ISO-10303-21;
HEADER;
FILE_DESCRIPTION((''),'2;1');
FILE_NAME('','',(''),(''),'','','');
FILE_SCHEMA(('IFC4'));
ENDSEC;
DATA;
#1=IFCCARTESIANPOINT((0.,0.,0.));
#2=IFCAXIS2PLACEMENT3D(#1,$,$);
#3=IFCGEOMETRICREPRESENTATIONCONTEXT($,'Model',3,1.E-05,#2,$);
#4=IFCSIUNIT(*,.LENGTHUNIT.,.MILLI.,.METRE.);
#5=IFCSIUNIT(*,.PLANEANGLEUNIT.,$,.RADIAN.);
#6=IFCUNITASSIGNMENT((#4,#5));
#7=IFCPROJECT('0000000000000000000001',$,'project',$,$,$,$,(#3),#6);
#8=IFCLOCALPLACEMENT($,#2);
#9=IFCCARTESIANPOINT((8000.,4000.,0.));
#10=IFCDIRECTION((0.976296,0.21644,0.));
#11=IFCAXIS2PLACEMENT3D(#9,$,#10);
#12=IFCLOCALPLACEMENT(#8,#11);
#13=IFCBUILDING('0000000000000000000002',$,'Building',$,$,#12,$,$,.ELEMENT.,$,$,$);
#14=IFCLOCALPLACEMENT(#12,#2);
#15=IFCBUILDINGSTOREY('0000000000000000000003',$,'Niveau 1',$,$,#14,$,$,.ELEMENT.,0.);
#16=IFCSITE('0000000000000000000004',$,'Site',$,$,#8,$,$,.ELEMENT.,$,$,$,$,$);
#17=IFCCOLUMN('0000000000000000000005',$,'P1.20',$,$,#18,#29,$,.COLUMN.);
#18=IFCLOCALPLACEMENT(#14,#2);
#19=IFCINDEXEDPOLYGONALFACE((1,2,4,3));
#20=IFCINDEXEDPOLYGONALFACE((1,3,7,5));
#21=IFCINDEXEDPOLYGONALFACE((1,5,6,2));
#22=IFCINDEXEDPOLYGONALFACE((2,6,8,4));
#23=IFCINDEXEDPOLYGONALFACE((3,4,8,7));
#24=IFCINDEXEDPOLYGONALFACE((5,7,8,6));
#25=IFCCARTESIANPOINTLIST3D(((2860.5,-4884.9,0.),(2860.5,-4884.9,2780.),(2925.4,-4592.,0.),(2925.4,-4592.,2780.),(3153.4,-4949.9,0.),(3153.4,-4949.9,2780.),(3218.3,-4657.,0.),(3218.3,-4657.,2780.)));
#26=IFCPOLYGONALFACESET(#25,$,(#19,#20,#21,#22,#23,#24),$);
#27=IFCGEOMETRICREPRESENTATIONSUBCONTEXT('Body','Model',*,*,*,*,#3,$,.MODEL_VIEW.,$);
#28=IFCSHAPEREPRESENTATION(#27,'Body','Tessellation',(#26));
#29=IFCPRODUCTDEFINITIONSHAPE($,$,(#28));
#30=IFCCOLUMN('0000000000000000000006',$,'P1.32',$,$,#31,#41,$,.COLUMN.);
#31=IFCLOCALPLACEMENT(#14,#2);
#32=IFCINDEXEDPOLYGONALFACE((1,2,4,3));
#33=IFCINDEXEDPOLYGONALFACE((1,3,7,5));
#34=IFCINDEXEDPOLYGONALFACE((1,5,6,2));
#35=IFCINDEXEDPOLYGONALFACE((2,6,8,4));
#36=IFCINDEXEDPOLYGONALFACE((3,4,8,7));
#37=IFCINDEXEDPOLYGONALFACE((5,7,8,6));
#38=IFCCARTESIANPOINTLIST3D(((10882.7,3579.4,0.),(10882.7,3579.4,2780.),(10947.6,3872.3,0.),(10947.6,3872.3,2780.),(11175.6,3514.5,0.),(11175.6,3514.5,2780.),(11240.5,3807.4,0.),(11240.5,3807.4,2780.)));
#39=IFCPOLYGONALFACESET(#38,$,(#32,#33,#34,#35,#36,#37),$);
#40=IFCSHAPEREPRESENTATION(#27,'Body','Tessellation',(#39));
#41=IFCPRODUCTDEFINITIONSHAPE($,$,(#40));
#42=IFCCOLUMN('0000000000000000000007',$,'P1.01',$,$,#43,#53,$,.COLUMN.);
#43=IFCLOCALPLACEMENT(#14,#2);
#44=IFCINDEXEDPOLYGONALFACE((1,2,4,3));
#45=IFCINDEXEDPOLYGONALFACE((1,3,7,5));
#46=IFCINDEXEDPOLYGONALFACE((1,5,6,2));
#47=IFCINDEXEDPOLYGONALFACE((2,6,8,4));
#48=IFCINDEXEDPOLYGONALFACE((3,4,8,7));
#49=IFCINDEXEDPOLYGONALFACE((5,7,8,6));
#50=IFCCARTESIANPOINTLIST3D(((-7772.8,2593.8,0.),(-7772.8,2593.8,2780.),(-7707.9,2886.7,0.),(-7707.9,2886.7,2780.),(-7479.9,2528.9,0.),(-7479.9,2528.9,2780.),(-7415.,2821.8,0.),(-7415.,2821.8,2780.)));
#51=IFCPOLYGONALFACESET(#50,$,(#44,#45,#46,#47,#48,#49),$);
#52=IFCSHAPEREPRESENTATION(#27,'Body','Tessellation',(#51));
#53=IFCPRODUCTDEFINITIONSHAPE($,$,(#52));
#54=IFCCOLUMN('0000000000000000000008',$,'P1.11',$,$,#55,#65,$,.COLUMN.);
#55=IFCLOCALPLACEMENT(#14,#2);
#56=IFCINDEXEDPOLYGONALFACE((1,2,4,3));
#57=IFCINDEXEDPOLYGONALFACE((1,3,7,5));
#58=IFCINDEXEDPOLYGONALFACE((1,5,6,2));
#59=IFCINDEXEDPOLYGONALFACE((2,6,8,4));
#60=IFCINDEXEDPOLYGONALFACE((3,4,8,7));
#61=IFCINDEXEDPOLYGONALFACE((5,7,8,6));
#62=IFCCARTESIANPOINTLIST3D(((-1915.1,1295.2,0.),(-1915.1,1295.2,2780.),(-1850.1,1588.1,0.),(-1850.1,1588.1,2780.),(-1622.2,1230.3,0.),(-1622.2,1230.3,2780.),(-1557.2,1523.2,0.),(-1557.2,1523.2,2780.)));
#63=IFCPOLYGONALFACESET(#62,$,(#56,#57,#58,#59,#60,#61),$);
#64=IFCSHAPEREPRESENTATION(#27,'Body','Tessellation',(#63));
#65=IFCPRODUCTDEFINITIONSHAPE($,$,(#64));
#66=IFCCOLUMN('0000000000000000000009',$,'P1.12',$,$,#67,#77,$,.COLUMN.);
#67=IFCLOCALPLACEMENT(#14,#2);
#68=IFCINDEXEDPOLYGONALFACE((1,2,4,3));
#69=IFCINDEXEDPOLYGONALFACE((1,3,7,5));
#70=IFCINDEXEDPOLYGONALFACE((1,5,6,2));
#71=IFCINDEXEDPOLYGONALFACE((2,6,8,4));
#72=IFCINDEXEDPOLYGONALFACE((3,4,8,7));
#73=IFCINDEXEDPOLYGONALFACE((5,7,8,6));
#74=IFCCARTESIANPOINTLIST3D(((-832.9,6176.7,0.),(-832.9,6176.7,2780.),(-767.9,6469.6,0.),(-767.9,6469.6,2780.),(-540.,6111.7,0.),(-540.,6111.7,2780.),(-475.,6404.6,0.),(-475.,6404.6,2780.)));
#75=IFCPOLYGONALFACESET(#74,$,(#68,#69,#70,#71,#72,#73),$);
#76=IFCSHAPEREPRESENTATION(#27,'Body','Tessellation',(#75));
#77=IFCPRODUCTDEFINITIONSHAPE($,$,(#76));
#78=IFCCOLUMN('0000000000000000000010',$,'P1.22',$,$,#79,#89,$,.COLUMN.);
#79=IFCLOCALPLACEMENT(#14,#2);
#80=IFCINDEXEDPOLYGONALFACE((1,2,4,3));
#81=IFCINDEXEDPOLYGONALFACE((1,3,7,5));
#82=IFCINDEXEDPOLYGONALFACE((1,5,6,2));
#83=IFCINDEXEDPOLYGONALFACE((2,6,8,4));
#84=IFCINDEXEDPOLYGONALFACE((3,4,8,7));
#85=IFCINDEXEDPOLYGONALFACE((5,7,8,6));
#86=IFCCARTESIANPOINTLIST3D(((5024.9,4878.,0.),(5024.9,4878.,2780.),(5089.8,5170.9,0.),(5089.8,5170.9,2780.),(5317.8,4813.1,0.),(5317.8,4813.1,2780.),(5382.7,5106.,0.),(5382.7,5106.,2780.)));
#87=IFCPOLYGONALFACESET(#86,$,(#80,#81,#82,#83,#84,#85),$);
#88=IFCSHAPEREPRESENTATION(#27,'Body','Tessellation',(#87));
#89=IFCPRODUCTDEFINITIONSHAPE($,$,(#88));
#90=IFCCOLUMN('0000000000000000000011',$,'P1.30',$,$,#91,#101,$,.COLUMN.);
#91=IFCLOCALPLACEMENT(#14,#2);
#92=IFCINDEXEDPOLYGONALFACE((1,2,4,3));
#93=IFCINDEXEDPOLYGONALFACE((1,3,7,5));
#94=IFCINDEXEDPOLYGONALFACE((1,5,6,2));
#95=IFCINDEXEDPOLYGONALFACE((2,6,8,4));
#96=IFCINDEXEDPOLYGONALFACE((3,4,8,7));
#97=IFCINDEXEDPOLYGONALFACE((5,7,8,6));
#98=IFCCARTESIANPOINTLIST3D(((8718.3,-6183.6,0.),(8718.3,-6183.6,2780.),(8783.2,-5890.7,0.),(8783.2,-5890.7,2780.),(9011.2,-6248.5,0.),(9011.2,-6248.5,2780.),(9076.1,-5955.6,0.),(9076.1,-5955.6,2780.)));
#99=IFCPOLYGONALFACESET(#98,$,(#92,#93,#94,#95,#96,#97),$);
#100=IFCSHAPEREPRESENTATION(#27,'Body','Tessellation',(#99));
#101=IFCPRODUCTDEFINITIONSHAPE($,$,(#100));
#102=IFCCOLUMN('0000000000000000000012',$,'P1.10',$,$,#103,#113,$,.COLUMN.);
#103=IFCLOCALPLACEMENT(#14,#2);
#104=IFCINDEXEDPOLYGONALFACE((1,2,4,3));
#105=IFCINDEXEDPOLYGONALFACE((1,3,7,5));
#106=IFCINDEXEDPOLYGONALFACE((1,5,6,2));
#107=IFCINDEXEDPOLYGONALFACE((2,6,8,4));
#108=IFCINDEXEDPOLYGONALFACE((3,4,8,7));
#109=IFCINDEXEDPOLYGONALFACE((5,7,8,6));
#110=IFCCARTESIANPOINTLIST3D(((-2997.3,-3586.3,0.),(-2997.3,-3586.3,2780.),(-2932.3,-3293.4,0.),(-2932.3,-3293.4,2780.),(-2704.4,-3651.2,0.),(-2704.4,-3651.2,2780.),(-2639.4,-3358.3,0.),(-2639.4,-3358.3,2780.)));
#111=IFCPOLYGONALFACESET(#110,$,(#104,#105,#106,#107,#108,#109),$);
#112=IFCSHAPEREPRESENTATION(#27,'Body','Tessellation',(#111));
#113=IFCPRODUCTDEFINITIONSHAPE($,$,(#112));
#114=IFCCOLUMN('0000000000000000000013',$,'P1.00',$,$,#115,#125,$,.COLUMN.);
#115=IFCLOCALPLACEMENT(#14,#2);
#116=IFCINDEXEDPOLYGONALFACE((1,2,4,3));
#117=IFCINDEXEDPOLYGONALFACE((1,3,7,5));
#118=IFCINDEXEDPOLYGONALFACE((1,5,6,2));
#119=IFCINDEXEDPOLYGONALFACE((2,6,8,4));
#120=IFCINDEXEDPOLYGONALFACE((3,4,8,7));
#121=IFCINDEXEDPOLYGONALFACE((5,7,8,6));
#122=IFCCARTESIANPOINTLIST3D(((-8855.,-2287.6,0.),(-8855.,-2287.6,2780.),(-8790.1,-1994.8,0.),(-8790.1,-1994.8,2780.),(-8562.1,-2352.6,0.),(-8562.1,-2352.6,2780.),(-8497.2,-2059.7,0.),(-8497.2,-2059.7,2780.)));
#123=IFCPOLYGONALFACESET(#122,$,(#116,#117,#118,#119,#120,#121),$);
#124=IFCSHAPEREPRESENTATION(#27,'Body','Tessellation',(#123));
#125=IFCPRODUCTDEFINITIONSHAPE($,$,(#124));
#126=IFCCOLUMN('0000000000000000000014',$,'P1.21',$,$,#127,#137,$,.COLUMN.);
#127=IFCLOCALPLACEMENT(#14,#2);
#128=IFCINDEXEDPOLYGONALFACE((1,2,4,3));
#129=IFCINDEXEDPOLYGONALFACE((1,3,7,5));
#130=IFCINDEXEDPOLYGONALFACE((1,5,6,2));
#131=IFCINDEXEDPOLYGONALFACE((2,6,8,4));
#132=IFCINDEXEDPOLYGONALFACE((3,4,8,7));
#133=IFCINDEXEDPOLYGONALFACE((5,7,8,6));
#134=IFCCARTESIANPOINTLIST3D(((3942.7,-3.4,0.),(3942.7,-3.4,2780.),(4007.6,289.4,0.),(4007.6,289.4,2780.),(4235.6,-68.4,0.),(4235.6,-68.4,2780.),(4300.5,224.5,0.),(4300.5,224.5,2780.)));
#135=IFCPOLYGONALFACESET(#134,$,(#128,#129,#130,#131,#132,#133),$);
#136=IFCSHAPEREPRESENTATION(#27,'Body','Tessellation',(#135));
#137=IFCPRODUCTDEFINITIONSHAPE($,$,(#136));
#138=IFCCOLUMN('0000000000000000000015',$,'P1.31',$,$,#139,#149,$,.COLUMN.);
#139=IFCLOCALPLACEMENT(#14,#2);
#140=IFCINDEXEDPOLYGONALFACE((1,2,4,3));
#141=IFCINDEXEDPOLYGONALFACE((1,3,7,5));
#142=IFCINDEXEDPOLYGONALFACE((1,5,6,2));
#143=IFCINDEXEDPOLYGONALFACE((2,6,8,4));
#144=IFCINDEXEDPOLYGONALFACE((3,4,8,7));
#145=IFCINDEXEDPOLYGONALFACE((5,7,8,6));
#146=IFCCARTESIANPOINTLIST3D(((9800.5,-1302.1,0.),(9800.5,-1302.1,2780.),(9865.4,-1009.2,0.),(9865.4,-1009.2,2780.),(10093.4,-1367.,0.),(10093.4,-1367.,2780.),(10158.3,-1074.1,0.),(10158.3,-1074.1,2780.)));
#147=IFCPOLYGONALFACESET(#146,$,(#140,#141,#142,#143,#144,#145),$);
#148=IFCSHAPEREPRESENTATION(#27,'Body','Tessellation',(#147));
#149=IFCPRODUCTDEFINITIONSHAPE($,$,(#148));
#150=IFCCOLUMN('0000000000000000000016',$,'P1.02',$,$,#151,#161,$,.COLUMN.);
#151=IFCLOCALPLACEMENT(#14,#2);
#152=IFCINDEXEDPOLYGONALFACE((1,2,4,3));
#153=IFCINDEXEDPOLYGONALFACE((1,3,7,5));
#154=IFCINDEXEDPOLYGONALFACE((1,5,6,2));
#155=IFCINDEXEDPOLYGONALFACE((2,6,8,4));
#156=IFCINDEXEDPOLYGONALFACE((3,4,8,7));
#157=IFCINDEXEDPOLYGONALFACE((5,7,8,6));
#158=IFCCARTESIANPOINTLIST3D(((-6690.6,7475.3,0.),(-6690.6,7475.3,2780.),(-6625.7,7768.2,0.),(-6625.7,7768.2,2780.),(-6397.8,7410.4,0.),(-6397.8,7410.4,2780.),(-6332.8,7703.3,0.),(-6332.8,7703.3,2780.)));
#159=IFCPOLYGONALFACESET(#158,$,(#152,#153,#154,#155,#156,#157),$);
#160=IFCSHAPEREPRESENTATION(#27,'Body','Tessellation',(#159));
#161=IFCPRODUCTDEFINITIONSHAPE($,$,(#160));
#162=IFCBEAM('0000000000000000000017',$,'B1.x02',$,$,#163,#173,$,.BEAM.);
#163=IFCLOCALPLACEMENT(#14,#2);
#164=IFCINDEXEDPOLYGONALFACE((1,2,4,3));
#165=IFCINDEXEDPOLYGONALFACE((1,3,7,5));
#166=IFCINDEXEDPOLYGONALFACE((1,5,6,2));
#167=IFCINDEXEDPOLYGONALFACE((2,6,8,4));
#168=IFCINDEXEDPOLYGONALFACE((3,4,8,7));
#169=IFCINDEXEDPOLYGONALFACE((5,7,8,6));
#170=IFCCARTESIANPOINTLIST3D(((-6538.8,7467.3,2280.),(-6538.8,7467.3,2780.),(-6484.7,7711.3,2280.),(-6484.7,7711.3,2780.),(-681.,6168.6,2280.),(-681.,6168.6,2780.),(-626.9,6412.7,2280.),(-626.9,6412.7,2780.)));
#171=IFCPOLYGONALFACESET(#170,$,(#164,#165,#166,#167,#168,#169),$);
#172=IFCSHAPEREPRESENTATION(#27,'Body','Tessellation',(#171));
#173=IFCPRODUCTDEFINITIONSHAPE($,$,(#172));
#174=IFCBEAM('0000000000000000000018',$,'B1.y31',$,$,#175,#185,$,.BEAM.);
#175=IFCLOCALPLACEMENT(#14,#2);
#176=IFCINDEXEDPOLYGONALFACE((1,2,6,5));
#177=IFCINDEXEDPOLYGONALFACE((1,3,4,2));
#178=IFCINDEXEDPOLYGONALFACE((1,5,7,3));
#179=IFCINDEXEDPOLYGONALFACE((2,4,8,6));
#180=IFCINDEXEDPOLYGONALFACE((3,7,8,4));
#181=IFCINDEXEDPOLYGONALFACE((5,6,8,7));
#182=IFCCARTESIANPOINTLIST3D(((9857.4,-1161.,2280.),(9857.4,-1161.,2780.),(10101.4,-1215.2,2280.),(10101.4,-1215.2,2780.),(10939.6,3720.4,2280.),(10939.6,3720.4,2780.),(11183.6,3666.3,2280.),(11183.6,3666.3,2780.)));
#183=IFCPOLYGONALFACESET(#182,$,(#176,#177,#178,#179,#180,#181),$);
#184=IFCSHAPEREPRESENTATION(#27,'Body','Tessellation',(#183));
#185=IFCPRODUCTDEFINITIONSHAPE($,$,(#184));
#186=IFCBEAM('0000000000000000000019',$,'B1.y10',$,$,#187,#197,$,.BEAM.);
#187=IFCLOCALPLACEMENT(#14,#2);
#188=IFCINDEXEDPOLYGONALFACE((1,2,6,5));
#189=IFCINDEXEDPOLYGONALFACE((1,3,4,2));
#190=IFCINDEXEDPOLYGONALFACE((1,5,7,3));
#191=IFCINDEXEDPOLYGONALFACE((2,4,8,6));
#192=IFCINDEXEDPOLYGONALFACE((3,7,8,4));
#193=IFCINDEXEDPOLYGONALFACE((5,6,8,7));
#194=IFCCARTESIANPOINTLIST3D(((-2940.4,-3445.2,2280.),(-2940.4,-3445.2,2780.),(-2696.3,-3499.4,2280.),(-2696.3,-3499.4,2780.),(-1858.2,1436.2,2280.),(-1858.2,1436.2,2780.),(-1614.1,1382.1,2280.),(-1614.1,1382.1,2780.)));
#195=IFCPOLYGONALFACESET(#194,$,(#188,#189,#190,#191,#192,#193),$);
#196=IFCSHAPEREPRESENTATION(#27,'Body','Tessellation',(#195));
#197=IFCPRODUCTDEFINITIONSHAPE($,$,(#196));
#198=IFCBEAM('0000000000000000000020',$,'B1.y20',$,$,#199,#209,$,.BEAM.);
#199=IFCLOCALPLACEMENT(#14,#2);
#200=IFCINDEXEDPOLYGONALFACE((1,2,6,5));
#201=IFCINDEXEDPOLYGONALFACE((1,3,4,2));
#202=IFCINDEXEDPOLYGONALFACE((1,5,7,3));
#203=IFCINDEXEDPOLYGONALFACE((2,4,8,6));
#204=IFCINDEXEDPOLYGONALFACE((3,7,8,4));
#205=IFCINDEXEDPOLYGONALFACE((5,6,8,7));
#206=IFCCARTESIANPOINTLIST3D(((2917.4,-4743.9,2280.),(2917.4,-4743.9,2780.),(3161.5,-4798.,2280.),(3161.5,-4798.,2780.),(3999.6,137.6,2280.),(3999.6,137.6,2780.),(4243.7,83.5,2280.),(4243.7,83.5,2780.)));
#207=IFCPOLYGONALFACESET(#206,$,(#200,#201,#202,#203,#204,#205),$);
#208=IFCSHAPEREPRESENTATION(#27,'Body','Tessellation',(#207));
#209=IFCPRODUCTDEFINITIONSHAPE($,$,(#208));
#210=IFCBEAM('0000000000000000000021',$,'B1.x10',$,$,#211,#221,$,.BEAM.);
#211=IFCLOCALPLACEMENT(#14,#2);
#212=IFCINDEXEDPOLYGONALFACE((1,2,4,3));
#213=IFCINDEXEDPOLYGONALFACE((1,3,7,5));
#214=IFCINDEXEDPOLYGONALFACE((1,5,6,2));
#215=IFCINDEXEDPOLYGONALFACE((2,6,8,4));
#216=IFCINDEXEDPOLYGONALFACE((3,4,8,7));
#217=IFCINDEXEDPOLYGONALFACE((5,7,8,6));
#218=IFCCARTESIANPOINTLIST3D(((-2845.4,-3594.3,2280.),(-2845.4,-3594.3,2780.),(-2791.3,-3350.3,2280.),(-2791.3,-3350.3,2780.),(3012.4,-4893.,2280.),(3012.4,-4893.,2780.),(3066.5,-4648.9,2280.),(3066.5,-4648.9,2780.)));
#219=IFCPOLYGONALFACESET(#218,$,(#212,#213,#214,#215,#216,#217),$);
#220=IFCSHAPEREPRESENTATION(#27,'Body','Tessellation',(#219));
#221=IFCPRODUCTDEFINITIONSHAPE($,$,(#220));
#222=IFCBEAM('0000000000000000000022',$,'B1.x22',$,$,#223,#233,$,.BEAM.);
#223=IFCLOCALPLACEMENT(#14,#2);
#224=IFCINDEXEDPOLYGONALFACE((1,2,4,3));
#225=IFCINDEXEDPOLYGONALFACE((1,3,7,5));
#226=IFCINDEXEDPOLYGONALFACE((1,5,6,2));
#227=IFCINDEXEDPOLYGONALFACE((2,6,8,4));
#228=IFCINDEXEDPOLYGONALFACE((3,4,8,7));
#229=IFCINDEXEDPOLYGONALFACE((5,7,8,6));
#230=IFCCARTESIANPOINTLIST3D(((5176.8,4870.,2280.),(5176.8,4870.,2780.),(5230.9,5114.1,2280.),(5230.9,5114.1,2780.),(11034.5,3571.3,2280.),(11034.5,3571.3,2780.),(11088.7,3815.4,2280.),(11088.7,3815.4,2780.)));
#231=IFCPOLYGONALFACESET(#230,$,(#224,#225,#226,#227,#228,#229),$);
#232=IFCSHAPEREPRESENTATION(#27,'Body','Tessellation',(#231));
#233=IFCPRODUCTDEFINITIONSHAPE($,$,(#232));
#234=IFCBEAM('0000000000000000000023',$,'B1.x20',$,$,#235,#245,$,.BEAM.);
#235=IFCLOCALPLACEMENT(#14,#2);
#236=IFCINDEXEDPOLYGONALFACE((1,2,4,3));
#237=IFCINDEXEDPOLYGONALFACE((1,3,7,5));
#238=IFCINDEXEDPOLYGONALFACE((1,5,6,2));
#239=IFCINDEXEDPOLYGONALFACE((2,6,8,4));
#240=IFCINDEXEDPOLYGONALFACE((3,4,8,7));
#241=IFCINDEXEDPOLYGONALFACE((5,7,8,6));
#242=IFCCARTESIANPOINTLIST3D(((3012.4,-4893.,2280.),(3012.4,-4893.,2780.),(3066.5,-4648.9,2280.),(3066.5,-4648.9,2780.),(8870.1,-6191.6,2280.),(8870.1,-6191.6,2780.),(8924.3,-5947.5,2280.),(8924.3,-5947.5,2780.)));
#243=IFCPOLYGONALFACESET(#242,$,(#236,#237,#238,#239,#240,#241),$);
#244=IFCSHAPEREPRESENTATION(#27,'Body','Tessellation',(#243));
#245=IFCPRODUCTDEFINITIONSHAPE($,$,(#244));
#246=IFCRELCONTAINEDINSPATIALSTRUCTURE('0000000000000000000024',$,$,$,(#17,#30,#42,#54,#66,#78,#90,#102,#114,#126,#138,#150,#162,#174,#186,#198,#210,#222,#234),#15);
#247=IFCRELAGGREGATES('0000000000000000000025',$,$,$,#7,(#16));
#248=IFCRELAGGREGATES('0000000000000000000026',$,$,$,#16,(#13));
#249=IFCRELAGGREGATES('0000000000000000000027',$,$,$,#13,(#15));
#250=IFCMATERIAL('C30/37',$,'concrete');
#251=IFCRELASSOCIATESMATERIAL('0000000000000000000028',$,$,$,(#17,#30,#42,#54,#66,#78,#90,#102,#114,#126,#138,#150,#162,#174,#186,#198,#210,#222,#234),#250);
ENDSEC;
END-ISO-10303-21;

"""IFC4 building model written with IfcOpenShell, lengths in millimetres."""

from ifc_helpers import new_model, si_unit, frame, origin, place, context, subcontext, project, spatial, rectangle, extrude, material, element, save


model = new_model("IFC4")

# Units and contexts
model_context = context("Model", 3, precision=1e-05, world=origin())
body_context = subcontext(model_context, "Body", "Model", "MODEL_VIEW")
ifc_project = project(units=[si_unit("LENGTHUNIT", "METRE", prefix="MILLI"), si_unit("PLANEANGLEUNIT", "RADIAN")], contexts=[model_context])

# Site, building, storey
site_placement = place(None, origin())
site = spatial("IfcSite", under=ifc_project, at=site_placement, Name="Site", CompositionType="ELEMENT")
building_placement = place(site_placement, frame((8000.0, 4000.0, 0.0), x_axis=(0.976296, 0.21644, 0.0)))
building = spatial("IfcBuilding", under=site, at=building_placement, Name="Building", CompositionType="ELEMENT")
storey_placement = place(building_placement, origin())
storey = spatial("IfcBuildingStorey", under=building, at=storey_placement, Name="Niveau 1", CompositionType="ELEMENT", Elevation=0.0)

# Columns
ifc_material = material(Name="C30/37", Category="concrete")
for number, where, z_axis, x_axis, name in (
    (1, (3039.4, -4770.9, 0.0), (0.0, 0.0, 1.0), (0.976296, -0.21644, 0.0), "P1.20"),
    (2, (11061.6, 3693.4, 0.0), (0.0, 0.0, 1.0), (0.976296, -0.21644, 0.0), "P1.32"),
    (3, (-7593.9, 2707.8, 0.0), (0.0, 0.0, 1.0), (0.976296, -0.21644, 0.0), "P1.01"),
    (4, (-1736.2, 1409.2, 0.0), (0.0, 0.0, 1.0), (0.976296, -0.21644, 0.0), "P1.11"),
    (5, (-654.0, 6290.7, 0.0), (0.0, 0.0, 1.0), (0.976296, -0.21644, 0.0), "P1.12"),
    (6, (5203.8, 4992.0, 0.0), (0.0, 0.0, 1.0), (0.976296, -0.21644, 0.0), "P1.22"),
    (7, (8897.2, -6069.6, 0.0), (0.0, 0.0, 1.0), (0.976296, -0.21644, 0.0), "P1.30"),
    (8, (-2818.4, -3472.3, 0.0), (0.0, 0.0, 1.0), (0.976296, -0.21644, 0.0), "P1.10"),
    (9, (-8676.1, -2173.7, 0.0), (0.0, 0.0, 1.0), (0.976296, -0.21644, 0.0), "P1.00"),
    (10, (4121.6, 110.5, 0.0), (0.0, 0.0, 1.0), (0.976296, -0.21644, 0.0), "P1.21"),
    (11, (9979.4, -1188.1, 0.0), (0.0, 0.0, 1.0), (0.976296, -0.21644, 0.0), "P1.31"),
    (12, (-6511.7, 7589.3, 0.0), (0.0, 0.0, 1.0), (0.976296, -0.21644, 0.0), "P1.02"),
):
    element("IfcColumn", number, at=place(storey_placement, frame(where, z_axis=z_axis, x_axis=x_axis)), inside=storey, material=ifc_material, Name=name, PredefinedType="COLUMN", context=body_context, shape_type="SweptSolid", body=[
        extrude(rectangle(XDim=300.0, YDim=300.0), origin(), (0.0, 0.0, 1.0), 2780.0),
    ])

# Beams
beam_1_placement = place(storey_placement, frame((-6511.7, 7589.3, 2530.0), z_axis=(0.976296, -0.21644, 0.0), x_axis=(0.21644, 0.976296, 0.0)))
element("IfcBeam", 13, at=beam_1_placement, inside=storey, material=ifc_material, Name="B1.x02", PredefinedType="BEAM", context=body_context, shape_type="SweptSolid", body=[
    extrude(rectangle(XDim=250.0, YDim=500.0), origin(), (0.0, 0.0, 1.0), 6000.0),
])
for number, where, z_axis, x_axis, name in (
    (14, (9979.4, -1188.1, 2530.0), (0.21644, 0.976296, 0.0), (-0.976296, 0.21644, 0.0), "B1.y31"),
    (15, (-2818.4, -3472.3, 2530.0), (0.21644, 0.976296, 0.0), (-0.976296, 0.21644, 0.0), "B1.y10"),
    (16, (3039.4, -4770.9, 2530.0), (0.21644, 0.976296, 0.0), (-0.976296, 0.21644, 0.0), "B1.y20"),
):
    element("IfcBeam", number, at=place(storey_placement, frame(where, z_axis=z_axis, x_axis=x_axis)), inside=storey, material=ifc_material, Name=name, PredefinedType="BEAM", context=body_context, shape_type="SweptSolid", body=[
        extrude(rectangle(XDim=250.0, YDim=500.0), origin(), (0.0, 0.0, 1.0), 5000.0),
    ])
for number, where, z_axis, x_axis, name in (
    (17, (-2818.4, -3472.3, 2530.0), (0.976296, -0.21644, 0.0), (0.21644, 0.976296, 0.0), "B1.x10"),
    (18, (5203.8, 4992.0, 2530.0), (0.976296, -0.21644, 0.0), (0.21644, 0.976296, 0.0), "B1.x22"),
    (19, (3039.4, -4770.9, 2530.0), (0.976296, -0.21644, 0.0), (0.21644, 0.976296, 0.0), "B1.x20"),
):
    element("IfcBeam", number, at=place(storey_placement, frame(where, z_axis=z_axis, x_axis=x_axis)), inside=storey, material=ifc_material, Name=name, PredefinedType="BEAM", context=body_context, shape_type="SweptSolid", body=[
        extrude(rectangle(XDim=250.0, YDim=500.0), origin(), (0.0, 0.0, 1.0), 6000.0),
    ])

save(model, "model.ifc")
